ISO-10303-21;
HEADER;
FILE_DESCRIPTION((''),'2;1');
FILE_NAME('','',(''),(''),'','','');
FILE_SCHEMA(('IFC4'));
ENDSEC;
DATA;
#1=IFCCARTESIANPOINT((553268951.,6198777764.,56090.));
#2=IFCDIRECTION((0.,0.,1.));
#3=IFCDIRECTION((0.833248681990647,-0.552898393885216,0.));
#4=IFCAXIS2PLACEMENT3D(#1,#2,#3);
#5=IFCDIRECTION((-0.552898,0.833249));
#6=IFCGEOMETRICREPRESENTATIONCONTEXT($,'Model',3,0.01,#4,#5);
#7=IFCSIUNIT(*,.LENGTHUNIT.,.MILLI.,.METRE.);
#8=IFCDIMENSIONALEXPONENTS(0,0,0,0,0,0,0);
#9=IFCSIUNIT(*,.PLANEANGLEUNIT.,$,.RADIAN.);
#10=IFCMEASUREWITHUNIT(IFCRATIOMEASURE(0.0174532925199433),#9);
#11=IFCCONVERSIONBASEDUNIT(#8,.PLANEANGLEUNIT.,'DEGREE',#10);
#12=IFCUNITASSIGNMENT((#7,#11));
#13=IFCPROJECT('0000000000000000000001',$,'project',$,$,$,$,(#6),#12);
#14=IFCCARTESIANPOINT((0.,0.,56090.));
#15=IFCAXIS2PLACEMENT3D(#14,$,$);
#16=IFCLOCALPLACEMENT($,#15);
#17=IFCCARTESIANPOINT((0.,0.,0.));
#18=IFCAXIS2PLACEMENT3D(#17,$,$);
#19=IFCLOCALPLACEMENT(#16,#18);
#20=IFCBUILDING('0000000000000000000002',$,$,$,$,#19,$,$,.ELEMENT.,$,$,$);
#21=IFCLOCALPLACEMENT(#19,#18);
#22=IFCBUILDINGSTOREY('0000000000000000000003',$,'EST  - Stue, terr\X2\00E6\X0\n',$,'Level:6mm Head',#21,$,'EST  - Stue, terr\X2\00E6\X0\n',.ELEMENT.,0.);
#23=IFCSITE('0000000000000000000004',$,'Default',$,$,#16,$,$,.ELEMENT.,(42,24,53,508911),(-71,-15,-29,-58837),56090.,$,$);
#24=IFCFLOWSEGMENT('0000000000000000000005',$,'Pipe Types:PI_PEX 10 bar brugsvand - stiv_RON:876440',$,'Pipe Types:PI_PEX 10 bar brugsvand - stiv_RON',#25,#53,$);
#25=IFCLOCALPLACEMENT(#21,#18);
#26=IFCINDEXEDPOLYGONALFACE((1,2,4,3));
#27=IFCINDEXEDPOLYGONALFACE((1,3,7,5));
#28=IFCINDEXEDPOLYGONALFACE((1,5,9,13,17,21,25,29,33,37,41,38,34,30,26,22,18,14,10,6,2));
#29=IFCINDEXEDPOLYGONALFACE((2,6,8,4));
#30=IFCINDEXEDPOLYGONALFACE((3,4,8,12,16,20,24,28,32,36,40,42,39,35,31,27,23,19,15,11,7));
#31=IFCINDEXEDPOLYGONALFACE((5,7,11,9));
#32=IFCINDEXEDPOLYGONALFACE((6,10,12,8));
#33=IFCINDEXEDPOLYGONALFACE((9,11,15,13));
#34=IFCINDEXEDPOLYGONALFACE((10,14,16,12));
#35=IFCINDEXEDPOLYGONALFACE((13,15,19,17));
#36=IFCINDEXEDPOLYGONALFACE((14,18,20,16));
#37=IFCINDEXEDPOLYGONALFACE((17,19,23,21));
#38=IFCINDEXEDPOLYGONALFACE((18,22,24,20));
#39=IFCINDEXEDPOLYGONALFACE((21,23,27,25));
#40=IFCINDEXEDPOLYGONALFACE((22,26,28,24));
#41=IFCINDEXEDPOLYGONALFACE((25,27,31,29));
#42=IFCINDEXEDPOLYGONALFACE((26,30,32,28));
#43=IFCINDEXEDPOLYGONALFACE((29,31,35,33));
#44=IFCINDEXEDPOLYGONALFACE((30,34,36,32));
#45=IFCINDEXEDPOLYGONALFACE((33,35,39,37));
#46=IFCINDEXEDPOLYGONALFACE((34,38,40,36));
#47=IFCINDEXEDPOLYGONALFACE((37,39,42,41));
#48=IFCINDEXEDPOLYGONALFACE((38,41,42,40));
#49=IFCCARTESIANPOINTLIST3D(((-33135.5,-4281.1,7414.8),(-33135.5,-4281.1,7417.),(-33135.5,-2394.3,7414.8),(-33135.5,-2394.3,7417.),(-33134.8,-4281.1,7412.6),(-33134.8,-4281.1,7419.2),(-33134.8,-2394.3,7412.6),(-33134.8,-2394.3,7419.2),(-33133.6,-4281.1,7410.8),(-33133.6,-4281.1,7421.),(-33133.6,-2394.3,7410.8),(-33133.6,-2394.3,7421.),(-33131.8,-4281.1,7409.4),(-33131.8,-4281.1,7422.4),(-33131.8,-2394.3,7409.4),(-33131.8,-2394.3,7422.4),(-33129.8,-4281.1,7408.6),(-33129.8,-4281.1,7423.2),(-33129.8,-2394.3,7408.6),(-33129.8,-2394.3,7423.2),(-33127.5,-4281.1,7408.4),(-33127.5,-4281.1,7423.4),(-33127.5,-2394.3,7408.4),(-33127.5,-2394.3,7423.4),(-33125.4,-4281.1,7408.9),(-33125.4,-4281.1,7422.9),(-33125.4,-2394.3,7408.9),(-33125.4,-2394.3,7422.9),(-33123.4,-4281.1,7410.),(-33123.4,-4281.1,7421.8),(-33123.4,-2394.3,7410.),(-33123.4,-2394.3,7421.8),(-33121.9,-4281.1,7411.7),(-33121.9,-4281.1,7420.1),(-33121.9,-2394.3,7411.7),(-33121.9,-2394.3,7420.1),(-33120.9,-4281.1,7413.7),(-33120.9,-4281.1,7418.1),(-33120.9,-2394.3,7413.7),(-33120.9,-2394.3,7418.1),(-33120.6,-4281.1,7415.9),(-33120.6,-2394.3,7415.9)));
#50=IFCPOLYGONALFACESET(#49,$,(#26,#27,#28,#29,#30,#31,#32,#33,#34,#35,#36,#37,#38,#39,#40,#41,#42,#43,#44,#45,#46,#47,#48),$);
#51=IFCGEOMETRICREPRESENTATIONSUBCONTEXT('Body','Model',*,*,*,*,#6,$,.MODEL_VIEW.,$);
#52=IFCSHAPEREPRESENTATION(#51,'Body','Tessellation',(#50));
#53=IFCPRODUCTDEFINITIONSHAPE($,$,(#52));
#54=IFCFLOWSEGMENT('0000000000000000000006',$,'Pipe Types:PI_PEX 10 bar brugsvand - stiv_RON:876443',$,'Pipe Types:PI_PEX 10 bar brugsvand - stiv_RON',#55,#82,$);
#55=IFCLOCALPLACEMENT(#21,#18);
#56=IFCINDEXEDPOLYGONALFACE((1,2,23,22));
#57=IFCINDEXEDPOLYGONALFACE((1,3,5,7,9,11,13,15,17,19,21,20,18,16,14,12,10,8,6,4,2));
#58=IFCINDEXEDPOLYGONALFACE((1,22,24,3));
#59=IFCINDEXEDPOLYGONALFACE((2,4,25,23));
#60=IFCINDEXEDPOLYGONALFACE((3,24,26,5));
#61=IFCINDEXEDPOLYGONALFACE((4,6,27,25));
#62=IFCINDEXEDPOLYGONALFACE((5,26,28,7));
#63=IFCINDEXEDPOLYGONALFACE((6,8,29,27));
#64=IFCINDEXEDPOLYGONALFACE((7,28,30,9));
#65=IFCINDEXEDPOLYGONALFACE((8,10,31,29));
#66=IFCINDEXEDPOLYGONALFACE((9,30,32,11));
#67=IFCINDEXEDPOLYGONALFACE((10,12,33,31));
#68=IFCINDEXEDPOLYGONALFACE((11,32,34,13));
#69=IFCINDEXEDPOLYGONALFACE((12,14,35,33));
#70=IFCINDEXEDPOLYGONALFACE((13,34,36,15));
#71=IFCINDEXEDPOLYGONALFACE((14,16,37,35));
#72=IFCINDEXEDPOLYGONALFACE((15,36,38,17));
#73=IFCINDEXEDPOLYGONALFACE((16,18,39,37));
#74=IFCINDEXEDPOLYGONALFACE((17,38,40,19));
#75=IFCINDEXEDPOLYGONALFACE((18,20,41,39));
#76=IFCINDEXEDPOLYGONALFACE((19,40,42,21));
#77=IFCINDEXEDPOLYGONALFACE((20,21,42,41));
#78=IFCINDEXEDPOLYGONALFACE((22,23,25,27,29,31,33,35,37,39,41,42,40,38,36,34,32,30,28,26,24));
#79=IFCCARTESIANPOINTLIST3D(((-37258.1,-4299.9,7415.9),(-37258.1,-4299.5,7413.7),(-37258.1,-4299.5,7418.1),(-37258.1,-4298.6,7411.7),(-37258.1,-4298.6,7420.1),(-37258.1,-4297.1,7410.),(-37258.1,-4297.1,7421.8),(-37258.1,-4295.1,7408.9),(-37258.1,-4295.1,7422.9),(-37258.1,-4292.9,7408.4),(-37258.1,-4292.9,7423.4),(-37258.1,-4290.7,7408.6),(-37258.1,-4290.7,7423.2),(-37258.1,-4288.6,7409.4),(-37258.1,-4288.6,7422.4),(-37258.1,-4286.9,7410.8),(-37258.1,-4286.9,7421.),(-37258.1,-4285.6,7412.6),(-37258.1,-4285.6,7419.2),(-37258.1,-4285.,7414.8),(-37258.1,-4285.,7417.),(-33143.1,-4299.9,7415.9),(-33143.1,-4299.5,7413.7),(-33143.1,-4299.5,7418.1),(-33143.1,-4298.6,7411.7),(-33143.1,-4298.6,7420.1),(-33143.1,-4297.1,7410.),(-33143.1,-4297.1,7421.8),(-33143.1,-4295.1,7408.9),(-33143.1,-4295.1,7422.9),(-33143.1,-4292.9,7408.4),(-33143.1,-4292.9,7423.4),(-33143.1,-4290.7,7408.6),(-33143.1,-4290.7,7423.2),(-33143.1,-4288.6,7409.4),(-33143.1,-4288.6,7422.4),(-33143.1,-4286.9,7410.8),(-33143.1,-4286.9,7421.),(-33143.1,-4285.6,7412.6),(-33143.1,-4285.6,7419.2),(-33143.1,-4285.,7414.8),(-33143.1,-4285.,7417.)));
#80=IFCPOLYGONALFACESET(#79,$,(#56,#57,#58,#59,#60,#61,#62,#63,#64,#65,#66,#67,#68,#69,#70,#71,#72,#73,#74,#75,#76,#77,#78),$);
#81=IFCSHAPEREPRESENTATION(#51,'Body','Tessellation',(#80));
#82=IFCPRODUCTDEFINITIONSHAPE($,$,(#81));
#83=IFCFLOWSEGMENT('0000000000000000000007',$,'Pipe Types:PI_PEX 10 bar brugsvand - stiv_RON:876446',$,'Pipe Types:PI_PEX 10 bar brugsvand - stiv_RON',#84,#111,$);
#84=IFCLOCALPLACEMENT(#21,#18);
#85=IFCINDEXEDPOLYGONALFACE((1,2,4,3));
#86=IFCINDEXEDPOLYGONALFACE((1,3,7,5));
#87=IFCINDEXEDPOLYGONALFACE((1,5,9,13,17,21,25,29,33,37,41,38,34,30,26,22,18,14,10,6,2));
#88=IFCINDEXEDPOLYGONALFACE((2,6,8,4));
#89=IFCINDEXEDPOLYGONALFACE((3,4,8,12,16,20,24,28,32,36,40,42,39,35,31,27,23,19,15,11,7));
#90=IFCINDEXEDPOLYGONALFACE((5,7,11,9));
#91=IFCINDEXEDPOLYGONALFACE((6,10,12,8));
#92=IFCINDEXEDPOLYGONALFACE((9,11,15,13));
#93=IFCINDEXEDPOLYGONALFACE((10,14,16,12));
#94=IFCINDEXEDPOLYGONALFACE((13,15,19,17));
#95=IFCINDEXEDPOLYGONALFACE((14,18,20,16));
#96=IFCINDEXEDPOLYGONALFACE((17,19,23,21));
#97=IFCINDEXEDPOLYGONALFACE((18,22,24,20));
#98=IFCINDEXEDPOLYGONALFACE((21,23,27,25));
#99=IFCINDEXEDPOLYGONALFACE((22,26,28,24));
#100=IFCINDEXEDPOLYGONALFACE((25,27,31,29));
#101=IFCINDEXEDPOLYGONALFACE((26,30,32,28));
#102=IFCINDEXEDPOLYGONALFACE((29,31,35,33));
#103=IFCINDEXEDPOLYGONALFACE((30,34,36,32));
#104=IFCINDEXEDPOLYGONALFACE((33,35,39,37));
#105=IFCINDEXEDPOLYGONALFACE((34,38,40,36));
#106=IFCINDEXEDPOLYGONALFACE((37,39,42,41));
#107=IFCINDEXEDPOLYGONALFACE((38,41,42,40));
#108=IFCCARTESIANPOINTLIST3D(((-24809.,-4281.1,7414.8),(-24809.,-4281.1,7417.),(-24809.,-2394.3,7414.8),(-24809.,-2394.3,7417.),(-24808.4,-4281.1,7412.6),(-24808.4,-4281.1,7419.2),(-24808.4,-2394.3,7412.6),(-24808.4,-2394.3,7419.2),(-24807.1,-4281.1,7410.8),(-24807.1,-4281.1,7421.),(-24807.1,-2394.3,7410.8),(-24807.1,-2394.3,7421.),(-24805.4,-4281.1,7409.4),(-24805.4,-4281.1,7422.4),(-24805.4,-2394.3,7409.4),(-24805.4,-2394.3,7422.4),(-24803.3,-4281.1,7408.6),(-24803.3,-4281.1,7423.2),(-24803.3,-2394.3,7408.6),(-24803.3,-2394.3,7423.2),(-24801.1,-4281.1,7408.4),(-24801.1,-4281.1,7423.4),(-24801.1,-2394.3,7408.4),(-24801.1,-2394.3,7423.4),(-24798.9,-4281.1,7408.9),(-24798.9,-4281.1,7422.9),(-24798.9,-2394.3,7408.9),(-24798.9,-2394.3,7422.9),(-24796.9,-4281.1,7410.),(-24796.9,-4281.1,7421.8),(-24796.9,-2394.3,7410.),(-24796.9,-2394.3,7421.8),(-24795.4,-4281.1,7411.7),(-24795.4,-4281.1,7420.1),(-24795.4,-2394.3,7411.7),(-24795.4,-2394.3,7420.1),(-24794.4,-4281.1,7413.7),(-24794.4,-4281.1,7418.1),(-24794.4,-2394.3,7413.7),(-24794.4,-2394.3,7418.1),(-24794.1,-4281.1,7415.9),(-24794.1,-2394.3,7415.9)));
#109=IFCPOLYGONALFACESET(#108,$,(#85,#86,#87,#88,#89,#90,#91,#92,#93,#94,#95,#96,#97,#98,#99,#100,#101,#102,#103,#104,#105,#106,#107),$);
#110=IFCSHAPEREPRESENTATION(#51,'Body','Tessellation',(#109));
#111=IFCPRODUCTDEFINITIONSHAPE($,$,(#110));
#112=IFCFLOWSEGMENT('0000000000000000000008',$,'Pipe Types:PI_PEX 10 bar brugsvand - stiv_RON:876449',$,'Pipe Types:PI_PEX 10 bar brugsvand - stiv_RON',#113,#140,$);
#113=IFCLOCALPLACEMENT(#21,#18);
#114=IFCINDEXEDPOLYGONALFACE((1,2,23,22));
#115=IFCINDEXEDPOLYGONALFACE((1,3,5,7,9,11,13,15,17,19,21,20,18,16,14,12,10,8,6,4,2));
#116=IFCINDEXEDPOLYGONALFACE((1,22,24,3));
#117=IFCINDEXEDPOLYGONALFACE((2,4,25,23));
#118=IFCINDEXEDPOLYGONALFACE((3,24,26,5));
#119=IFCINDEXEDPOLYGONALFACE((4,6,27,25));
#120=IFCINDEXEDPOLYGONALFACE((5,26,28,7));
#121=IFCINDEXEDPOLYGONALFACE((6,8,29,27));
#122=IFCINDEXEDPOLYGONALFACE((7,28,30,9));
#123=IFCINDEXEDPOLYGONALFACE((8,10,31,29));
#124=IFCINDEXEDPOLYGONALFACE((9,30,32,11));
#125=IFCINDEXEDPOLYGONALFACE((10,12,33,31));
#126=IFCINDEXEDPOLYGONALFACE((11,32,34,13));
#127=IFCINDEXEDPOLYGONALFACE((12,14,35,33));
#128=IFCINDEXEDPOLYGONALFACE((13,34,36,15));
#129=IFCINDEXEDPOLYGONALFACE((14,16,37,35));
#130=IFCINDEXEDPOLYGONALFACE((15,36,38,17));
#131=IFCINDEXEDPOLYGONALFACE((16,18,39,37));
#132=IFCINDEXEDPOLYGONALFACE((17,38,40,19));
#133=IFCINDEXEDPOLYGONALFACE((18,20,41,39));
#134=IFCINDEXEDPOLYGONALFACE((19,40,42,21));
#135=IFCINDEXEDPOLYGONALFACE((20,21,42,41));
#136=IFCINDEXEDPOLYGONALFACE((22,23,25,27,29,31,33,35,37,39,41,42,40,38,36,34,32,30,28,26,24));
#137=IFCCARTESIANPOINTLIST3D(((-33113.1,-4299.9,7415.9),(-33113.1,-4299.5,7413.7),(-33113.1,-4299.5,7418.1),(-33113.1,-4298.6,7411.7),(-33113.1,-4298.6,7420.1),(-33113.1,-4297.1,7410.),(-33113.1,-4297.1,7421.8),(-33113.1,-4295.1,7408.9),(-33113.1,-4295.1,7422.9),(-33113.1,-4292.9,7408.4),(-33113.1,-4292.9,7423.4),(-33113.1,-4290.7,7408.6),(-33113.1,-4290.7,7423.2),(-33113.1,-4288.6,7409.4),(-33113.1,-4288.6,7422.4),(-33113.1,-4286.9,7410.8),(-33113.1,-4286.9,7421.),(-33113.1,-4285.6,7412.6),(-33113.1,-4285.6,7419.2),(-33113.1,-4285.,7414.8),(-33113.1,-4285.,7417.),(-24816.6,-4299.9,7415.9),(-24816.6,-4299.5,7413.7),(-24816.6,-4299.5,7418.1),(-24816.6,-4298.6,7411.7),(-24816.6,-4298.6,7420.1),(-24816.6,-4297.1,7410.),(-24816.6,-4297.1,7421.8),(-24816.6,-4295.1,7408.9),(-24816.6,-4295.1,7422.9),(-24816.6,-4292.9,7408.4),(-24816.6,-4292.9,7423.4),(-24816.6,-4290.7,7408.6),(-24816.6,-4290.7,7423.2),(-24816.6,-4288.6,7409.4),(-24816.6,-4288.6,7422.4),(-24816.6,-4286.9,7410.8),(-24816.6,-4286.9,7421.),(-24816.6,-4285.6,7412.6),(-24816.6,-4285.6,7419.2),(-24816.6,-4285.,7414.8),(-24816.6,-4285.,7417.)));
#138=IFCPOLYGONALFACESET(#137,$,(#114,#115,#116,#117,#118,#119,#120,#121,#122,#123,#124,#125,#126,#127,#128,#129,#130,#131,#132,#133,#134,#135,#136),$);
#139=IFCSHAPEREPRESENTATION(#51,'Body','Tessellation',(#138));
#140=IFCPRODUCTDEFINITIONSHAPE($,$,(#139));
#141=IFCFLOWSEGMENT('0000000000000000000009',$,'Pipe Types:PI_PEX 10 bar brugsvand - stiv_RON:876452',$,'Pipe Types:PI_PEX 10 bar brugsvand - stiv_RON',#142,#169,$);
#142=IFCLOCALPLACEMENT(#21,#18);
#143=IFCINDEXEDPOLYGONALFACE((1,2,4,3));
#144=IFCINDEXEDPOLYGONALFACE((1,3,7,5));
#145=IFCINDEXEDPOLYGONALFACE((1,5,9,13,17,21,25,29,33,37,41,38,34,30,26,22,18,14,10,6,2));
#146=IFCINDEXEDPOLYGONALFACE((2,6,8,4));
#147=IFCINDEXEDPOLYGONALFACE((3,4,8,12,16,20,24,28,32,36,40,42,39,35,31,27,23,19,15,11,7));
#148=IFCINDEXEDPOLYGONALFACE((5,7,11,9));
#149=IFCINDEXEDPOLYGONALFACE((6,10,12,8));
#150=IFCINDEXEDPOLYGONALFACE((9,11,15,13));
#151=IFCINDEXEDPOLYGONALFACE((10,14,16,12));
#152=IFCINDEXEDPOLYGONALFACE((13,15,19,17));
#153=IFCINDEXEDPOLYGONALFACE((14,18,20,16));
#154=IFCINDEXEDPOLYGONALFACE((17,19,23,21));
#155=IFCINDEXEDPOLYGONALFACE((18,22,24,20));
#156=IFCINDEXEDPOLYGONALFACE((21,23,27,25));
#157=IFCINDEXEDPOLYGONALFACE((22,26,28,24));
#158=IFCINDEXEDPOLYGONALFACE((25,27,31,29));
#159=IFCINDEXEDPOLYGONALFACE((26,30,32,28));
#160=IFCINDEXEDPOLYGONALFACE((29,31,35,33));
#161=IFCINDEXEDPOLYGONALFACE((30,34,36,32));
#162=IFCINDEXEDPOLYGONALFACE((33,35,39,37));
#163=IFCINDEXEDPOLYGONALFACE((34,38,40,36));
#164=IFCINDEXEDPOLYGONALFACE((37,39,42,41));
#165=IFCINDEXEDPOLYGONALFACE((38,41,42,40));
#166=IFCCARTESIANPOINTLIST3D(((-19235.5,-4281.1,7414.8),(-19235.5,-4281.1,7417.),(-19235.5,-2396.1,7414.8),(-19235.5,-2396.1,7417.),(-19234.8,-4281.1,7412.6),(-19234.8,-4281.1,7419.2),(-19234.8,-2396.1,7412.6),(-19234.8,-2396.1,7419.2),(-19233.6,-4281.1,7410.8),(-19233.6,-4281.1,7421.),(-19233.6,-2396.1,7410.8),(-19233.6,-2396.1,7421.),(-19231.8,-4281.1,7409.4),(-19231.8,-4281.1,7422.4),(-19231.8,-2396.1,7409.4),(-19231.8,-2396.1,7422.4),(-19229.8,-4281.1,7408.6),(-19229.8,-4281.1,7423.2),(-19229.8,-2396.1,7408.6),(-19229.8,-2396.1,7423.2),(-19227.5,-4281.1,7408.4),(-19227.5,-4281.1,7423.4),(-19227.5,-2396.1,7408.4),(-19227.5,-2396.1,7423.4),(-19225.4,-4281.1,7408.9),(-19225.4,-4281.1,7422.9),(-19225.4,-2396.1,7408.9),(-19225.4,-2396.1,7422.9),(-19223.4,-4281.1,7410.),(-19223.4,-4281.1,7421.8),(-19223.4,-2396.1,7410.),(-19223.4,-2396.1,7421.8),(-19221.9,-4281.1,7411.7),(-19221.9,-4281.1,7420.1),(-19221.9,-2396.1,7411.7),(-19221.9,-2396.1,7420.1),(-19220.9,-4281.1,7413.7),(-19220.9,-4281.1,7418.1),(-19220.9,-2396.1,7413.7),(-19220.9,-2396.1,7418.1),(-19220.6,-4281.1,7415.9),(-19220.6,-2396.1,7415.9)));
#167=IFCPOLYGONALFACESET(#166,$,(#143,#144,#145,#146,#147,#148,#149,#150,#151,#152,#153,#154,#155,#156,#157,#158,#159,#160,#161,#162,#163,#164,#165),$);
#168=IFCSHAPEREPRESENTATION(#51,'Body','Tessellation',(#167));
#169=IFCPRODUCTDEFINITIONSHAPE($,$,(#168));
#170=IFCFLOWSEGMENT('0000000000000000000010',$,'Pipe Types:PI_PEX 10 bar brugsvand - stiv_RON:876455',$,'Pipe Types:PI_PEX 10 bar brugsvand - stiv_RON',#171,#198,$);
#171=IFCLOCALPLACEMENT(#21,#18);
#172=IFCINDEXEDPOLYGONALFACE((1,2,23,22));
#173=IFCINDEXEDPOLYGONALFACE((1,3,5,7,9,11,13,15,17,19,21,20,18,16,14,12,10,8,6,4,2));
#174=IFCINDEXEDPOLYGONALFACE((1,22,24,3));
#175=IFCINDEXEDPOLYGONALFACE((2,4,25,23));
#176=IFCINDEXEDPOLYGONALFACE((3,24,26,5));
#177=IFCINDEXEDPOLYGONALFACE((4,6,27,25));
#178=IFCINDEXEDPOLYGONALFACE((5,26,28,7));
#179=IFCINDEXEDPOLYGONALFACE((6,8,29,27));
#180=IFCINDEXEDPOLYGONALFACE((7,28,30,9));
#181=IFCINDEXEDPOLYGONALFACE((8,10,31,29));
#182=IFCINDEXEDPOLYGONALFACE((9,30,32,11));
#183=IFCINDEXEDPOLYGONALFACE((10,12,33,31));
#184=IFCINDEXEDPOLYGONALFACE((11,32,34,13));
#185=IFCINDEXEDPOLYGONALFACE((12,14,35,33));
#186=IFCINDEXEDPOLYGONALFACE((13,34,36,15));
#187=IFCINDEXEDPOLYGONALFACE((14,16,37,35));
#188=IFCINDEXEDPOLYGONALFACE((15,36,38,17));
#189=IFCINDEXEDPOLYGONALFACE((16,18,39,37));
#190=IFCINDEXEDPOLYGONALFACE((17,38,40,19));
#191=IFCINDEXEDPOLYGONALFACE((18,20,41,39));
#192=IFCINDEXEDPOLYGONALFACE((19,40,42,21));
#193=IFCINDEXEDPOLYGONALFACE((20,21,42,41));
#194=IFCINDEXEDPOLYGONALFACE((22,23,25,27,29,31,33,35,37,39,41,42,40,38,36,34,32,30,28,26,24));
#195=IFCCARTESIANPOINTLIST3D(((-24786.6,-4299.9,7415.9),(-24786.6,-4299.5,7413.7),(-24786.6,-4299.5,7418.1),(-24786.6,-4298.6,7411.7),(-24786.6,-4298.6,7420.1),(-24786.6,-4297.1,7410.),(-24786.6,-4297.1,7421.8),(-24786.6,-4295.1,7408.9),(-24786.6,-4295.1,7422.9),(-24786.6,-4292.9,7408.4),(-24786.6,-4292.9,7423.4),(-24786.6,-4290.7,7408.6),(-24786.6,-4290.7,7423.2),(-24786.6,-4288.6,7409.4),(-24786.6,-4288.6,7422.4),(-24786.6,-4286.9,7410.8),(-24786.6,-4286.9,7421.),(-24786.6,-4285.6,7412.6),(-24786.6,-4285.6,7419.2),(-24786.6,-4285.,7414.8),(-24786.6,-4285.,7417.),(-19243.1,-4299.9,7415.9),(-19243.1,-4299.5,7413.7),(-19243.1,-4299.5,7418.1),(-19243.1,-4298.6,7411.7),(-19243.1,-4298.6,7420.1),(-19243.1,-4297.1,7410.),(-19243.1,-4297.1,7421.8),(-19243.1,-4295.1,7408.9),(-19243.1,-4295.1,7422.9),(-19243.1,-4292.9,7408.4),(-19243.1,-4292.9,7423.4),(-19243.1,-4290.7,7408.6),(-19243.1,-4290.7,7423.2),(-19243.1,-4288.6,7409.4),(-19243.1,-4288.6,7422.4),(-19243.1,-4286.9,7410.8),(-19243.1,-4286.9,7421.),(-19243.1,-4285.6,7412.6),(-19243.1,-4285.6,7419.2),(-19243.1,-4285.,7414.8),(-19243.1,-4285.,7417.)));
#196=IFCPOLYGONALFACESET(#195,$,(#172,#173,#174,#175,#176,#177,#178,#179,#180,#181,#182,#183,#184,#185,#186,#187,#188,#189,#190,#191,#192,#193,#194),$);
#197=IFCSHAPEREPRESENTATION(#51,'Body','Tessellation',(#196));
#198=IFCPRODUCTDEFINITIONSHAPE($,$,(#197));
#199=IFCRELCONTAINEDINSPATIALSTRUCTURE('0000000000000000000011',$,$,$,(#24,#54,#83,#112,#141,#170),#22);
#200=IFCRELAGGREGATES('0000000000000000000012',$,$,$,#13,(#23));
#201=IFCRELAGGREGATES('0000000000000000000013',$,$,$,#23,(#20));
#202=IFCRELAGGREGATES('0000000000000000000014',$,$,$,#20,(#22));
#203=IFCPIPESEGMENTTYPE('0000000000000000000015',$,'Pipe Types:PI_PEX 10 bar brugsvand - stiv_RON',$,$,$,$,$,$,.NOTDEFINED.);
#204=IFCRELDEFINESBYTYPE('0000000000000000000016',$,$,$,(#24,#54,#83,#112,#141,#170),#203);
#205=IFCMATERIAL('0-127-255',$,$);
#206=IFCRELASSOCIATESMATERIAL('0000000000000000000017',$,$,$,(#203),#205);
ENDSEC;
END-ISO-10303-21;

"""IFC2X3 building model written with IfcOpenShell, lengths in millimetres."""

from ifc_helpers import new_model, entity, si_unit, converted_unit, direction, frame, origin, origin_2d_with_axis, place, context, subcontext, project, spatial, circle, extrude, material, type_object, element, save


model = new_model("IFC2X3")

# Units and contexts
model_context = context("Model", 3, precision=0.01, world=frame((553268951.0, 6198777764.0, 56090.0), z_axis=(0.0, 0.0, 1.0), x_axis=(0.833248681990647, -0.552898393885216, 0.0)), true_north=direction((-0.552898, 0.833249)))
body_context = subcontext(model_context, "Body", "Model", "MODEL_VIEW")
ifc_project = project(units=[si_unit("LENGTHUNIT", "METRE", prefix="MILLI"), converted_unit("PLANEANGLEUNIT", "DEGREE", entity("IfcRatioMeasure", 0.0174532925199433), si_unit("PLANEANGLEUNIT", "RADIAN"), dimensions=[0, 0, 0, 0, 0, 0, 0])], contexts=[model_context])

# Site, building, storey
site_placement = place(None, frame((0.0, 0.0, 56090.0)))
site = spatial("IfcSite", under=ifc_project, at=site_placement, Name="Default", CompositionType="ELEMENT", RefLatitude=(42, 24, 53, 508911), RefLongitude=(-71, -15, -29, -58837), RefElevation=56090.0)
building_placement = place(site_placement, origin())
building = spatial("IfcBuilding", under=site, at=building_placement, CompositionType="ELEMENT")
storey_placement = place(building_placement, frame((0.0, 0.0, 0.0)))
storey = spatial("IfcBuildingStorey", under=building, at=storey_placement, Name="EST  - Stue, terræn", ObjectType="Level:6mm Head", LongName="EST  - Stue, terræn", CompositionType="ELEMENT", Elevation=0.0)

# Flow segments
ifc_material_1 = material(Name="0-127-255")
pipe_segment_type_1 = type_object("IfcPipeSegmentType", Name="Pipe Types:PI_PEX 10 bar brugsvand - stiv_RON", PredefinedType="NOTDEFINED", material=ifc_material_1)
flow_segment_1_placement = place(storey_placement, origin())
element("IfcFlowSegment", 1, at=flow_segment_1_placement, inside=storey, type_object=pipe_segment_type_1, Name="Pipe Types:PI_PEX 10 bar brugsvand - stiv_RON:876440", ObjectType="Pipe Types:PI_PEX 10 bar brugsvand - stiv_RON", context=body_context, shape_type="SweptSolid", body=[
    extrude(circle(Radius=7.5, at=origin_2d_with_axis()), frame((-33128.1, -4281.1, 7415.9), z_axis=(0.0, 1.0, 0.0), x_axis=(1.0, 0.0, 0.0)), (0.0, 0.0, 1.0), 1886.8),
])
flow_segment_2_placement = place(storey_placement, origin())
element("IfcFlowSegment", 2, at=flow_segment_2_placement, inside=storey, type_object=pipe_segment_type_1, Name="Pipe Types:PI_PEX 10 bar brugsvand - stiv_RON:876443", ObjectType="Pipe Types:PI_PEX 10 bar brugsvand - stiv_RON", context=body_context, shape_type="SweptSolid", body=[
    extrude(circle(Radius=7.5, at=origin_2d_with_axis()), frame((-37258.1, -4292.4, 7415.9), z_axis=(1.0, 0.0, 0.0), x_axis=(0.0, -1.0, 0.0)), (0.0, 0.0, 1.0), 4115.0),
])
flow_segment_3_placement = place(storey_placement, origin())
element("IfcFlowSegment", 3, at=flow_segment_3_placement, inside=storey, type_object=pipe_segment_type_1, Name="Pipe Types:PI_PEX 10 bar brugsvand - stiv_RON:876446", ObjectType="Pipe Types:PI_PEX 10 bar brugsvand - stiv_RON", context=body_context, shape_type="SweptSolid", body=[
    extrude(circle(Radius=7.5, at=origin_2d_with_axis()), frame((-24801.6, -4281.1, 7415.9), z_axis=(0.0, 1.0, 0.0), x_axis=(1.0, 0.0, 0.0)), (0.0, 0.0, 1.0), 1886.8),
])
flow_segment_4_placement = place(storey_placement, origin())
element("IfcFlowSegment", 4, at=flow_segment_4_placement, inside=storey, type_object=pipe_segment_type_1, Name="Pipe Types:PI_PEX 10 bar brugsvand - stiv_RON:876449", ObjectType="Pipe Types:PI_PEX 10 bar brugsvand - stiv_RON", context=body_context, shape_type="SweptSolid", body=[
    extrude(circle(Radius=7.5, at=origin_2d_with_axis()), frame((-33113.1, -4292.4, 7415.9), z_axis=(1.0, 0.0, 0.0), x_axis=(0.0, -1.0, 0.0)), (0.0, 0.0, 1.0), 8296.5),
])
flow_segment_5_placement = place(storey_placement, origin())
element("IfcFlowSegment", 5, at=flow_segment_5_placement, inside=storey, type_object=pipe_segment_type_1, Name="Pipe Types:PI_PEX 10 bar brugsvand - stiv_RON:876452", ObjectType="Pipe Types:PI_PEX 10 bar brugsvand - stiv_RON", context=body_context, shape_type="SweptSolid", body=[
    extrude(circle(Radius=7.5, at=origin_2d_with_axis()), frame((-19228.1, -4281.1, 7415.9), z_axis=(0.0, 1.0, 0.0), x_axis=(1.0, 0.0, 0.0)), (0.0, 0.0, 1.0), 1885.0),
])
flow_segment_6_placement = place(storey_placement, origin())
element("IfcFlowSegment", 6, at=flow_segment_6_placement, inside=storey, type_object=pipe_segment_type_1, Name="Pipe Types:PI_PEX 10 bar brugsvand - stiv_RON:876455", ObjectType="Pipe Types:PI_PEX 10 bar brugsvand - stiv_RON", context=body_context, shape_type="SweptSolid", body=[
    extrude(circle(Radius=7.5, at=origin_2d_with_axis()), frame((-24786.6, -4292.4, 7415.9), z_axis=(1.0, 0.0, 0.0), x_axis=(0.0, -1.0, 0.0)), (0.0, 0.0, 1.0), 5543.5),
])

save(model, "model.ifc")
